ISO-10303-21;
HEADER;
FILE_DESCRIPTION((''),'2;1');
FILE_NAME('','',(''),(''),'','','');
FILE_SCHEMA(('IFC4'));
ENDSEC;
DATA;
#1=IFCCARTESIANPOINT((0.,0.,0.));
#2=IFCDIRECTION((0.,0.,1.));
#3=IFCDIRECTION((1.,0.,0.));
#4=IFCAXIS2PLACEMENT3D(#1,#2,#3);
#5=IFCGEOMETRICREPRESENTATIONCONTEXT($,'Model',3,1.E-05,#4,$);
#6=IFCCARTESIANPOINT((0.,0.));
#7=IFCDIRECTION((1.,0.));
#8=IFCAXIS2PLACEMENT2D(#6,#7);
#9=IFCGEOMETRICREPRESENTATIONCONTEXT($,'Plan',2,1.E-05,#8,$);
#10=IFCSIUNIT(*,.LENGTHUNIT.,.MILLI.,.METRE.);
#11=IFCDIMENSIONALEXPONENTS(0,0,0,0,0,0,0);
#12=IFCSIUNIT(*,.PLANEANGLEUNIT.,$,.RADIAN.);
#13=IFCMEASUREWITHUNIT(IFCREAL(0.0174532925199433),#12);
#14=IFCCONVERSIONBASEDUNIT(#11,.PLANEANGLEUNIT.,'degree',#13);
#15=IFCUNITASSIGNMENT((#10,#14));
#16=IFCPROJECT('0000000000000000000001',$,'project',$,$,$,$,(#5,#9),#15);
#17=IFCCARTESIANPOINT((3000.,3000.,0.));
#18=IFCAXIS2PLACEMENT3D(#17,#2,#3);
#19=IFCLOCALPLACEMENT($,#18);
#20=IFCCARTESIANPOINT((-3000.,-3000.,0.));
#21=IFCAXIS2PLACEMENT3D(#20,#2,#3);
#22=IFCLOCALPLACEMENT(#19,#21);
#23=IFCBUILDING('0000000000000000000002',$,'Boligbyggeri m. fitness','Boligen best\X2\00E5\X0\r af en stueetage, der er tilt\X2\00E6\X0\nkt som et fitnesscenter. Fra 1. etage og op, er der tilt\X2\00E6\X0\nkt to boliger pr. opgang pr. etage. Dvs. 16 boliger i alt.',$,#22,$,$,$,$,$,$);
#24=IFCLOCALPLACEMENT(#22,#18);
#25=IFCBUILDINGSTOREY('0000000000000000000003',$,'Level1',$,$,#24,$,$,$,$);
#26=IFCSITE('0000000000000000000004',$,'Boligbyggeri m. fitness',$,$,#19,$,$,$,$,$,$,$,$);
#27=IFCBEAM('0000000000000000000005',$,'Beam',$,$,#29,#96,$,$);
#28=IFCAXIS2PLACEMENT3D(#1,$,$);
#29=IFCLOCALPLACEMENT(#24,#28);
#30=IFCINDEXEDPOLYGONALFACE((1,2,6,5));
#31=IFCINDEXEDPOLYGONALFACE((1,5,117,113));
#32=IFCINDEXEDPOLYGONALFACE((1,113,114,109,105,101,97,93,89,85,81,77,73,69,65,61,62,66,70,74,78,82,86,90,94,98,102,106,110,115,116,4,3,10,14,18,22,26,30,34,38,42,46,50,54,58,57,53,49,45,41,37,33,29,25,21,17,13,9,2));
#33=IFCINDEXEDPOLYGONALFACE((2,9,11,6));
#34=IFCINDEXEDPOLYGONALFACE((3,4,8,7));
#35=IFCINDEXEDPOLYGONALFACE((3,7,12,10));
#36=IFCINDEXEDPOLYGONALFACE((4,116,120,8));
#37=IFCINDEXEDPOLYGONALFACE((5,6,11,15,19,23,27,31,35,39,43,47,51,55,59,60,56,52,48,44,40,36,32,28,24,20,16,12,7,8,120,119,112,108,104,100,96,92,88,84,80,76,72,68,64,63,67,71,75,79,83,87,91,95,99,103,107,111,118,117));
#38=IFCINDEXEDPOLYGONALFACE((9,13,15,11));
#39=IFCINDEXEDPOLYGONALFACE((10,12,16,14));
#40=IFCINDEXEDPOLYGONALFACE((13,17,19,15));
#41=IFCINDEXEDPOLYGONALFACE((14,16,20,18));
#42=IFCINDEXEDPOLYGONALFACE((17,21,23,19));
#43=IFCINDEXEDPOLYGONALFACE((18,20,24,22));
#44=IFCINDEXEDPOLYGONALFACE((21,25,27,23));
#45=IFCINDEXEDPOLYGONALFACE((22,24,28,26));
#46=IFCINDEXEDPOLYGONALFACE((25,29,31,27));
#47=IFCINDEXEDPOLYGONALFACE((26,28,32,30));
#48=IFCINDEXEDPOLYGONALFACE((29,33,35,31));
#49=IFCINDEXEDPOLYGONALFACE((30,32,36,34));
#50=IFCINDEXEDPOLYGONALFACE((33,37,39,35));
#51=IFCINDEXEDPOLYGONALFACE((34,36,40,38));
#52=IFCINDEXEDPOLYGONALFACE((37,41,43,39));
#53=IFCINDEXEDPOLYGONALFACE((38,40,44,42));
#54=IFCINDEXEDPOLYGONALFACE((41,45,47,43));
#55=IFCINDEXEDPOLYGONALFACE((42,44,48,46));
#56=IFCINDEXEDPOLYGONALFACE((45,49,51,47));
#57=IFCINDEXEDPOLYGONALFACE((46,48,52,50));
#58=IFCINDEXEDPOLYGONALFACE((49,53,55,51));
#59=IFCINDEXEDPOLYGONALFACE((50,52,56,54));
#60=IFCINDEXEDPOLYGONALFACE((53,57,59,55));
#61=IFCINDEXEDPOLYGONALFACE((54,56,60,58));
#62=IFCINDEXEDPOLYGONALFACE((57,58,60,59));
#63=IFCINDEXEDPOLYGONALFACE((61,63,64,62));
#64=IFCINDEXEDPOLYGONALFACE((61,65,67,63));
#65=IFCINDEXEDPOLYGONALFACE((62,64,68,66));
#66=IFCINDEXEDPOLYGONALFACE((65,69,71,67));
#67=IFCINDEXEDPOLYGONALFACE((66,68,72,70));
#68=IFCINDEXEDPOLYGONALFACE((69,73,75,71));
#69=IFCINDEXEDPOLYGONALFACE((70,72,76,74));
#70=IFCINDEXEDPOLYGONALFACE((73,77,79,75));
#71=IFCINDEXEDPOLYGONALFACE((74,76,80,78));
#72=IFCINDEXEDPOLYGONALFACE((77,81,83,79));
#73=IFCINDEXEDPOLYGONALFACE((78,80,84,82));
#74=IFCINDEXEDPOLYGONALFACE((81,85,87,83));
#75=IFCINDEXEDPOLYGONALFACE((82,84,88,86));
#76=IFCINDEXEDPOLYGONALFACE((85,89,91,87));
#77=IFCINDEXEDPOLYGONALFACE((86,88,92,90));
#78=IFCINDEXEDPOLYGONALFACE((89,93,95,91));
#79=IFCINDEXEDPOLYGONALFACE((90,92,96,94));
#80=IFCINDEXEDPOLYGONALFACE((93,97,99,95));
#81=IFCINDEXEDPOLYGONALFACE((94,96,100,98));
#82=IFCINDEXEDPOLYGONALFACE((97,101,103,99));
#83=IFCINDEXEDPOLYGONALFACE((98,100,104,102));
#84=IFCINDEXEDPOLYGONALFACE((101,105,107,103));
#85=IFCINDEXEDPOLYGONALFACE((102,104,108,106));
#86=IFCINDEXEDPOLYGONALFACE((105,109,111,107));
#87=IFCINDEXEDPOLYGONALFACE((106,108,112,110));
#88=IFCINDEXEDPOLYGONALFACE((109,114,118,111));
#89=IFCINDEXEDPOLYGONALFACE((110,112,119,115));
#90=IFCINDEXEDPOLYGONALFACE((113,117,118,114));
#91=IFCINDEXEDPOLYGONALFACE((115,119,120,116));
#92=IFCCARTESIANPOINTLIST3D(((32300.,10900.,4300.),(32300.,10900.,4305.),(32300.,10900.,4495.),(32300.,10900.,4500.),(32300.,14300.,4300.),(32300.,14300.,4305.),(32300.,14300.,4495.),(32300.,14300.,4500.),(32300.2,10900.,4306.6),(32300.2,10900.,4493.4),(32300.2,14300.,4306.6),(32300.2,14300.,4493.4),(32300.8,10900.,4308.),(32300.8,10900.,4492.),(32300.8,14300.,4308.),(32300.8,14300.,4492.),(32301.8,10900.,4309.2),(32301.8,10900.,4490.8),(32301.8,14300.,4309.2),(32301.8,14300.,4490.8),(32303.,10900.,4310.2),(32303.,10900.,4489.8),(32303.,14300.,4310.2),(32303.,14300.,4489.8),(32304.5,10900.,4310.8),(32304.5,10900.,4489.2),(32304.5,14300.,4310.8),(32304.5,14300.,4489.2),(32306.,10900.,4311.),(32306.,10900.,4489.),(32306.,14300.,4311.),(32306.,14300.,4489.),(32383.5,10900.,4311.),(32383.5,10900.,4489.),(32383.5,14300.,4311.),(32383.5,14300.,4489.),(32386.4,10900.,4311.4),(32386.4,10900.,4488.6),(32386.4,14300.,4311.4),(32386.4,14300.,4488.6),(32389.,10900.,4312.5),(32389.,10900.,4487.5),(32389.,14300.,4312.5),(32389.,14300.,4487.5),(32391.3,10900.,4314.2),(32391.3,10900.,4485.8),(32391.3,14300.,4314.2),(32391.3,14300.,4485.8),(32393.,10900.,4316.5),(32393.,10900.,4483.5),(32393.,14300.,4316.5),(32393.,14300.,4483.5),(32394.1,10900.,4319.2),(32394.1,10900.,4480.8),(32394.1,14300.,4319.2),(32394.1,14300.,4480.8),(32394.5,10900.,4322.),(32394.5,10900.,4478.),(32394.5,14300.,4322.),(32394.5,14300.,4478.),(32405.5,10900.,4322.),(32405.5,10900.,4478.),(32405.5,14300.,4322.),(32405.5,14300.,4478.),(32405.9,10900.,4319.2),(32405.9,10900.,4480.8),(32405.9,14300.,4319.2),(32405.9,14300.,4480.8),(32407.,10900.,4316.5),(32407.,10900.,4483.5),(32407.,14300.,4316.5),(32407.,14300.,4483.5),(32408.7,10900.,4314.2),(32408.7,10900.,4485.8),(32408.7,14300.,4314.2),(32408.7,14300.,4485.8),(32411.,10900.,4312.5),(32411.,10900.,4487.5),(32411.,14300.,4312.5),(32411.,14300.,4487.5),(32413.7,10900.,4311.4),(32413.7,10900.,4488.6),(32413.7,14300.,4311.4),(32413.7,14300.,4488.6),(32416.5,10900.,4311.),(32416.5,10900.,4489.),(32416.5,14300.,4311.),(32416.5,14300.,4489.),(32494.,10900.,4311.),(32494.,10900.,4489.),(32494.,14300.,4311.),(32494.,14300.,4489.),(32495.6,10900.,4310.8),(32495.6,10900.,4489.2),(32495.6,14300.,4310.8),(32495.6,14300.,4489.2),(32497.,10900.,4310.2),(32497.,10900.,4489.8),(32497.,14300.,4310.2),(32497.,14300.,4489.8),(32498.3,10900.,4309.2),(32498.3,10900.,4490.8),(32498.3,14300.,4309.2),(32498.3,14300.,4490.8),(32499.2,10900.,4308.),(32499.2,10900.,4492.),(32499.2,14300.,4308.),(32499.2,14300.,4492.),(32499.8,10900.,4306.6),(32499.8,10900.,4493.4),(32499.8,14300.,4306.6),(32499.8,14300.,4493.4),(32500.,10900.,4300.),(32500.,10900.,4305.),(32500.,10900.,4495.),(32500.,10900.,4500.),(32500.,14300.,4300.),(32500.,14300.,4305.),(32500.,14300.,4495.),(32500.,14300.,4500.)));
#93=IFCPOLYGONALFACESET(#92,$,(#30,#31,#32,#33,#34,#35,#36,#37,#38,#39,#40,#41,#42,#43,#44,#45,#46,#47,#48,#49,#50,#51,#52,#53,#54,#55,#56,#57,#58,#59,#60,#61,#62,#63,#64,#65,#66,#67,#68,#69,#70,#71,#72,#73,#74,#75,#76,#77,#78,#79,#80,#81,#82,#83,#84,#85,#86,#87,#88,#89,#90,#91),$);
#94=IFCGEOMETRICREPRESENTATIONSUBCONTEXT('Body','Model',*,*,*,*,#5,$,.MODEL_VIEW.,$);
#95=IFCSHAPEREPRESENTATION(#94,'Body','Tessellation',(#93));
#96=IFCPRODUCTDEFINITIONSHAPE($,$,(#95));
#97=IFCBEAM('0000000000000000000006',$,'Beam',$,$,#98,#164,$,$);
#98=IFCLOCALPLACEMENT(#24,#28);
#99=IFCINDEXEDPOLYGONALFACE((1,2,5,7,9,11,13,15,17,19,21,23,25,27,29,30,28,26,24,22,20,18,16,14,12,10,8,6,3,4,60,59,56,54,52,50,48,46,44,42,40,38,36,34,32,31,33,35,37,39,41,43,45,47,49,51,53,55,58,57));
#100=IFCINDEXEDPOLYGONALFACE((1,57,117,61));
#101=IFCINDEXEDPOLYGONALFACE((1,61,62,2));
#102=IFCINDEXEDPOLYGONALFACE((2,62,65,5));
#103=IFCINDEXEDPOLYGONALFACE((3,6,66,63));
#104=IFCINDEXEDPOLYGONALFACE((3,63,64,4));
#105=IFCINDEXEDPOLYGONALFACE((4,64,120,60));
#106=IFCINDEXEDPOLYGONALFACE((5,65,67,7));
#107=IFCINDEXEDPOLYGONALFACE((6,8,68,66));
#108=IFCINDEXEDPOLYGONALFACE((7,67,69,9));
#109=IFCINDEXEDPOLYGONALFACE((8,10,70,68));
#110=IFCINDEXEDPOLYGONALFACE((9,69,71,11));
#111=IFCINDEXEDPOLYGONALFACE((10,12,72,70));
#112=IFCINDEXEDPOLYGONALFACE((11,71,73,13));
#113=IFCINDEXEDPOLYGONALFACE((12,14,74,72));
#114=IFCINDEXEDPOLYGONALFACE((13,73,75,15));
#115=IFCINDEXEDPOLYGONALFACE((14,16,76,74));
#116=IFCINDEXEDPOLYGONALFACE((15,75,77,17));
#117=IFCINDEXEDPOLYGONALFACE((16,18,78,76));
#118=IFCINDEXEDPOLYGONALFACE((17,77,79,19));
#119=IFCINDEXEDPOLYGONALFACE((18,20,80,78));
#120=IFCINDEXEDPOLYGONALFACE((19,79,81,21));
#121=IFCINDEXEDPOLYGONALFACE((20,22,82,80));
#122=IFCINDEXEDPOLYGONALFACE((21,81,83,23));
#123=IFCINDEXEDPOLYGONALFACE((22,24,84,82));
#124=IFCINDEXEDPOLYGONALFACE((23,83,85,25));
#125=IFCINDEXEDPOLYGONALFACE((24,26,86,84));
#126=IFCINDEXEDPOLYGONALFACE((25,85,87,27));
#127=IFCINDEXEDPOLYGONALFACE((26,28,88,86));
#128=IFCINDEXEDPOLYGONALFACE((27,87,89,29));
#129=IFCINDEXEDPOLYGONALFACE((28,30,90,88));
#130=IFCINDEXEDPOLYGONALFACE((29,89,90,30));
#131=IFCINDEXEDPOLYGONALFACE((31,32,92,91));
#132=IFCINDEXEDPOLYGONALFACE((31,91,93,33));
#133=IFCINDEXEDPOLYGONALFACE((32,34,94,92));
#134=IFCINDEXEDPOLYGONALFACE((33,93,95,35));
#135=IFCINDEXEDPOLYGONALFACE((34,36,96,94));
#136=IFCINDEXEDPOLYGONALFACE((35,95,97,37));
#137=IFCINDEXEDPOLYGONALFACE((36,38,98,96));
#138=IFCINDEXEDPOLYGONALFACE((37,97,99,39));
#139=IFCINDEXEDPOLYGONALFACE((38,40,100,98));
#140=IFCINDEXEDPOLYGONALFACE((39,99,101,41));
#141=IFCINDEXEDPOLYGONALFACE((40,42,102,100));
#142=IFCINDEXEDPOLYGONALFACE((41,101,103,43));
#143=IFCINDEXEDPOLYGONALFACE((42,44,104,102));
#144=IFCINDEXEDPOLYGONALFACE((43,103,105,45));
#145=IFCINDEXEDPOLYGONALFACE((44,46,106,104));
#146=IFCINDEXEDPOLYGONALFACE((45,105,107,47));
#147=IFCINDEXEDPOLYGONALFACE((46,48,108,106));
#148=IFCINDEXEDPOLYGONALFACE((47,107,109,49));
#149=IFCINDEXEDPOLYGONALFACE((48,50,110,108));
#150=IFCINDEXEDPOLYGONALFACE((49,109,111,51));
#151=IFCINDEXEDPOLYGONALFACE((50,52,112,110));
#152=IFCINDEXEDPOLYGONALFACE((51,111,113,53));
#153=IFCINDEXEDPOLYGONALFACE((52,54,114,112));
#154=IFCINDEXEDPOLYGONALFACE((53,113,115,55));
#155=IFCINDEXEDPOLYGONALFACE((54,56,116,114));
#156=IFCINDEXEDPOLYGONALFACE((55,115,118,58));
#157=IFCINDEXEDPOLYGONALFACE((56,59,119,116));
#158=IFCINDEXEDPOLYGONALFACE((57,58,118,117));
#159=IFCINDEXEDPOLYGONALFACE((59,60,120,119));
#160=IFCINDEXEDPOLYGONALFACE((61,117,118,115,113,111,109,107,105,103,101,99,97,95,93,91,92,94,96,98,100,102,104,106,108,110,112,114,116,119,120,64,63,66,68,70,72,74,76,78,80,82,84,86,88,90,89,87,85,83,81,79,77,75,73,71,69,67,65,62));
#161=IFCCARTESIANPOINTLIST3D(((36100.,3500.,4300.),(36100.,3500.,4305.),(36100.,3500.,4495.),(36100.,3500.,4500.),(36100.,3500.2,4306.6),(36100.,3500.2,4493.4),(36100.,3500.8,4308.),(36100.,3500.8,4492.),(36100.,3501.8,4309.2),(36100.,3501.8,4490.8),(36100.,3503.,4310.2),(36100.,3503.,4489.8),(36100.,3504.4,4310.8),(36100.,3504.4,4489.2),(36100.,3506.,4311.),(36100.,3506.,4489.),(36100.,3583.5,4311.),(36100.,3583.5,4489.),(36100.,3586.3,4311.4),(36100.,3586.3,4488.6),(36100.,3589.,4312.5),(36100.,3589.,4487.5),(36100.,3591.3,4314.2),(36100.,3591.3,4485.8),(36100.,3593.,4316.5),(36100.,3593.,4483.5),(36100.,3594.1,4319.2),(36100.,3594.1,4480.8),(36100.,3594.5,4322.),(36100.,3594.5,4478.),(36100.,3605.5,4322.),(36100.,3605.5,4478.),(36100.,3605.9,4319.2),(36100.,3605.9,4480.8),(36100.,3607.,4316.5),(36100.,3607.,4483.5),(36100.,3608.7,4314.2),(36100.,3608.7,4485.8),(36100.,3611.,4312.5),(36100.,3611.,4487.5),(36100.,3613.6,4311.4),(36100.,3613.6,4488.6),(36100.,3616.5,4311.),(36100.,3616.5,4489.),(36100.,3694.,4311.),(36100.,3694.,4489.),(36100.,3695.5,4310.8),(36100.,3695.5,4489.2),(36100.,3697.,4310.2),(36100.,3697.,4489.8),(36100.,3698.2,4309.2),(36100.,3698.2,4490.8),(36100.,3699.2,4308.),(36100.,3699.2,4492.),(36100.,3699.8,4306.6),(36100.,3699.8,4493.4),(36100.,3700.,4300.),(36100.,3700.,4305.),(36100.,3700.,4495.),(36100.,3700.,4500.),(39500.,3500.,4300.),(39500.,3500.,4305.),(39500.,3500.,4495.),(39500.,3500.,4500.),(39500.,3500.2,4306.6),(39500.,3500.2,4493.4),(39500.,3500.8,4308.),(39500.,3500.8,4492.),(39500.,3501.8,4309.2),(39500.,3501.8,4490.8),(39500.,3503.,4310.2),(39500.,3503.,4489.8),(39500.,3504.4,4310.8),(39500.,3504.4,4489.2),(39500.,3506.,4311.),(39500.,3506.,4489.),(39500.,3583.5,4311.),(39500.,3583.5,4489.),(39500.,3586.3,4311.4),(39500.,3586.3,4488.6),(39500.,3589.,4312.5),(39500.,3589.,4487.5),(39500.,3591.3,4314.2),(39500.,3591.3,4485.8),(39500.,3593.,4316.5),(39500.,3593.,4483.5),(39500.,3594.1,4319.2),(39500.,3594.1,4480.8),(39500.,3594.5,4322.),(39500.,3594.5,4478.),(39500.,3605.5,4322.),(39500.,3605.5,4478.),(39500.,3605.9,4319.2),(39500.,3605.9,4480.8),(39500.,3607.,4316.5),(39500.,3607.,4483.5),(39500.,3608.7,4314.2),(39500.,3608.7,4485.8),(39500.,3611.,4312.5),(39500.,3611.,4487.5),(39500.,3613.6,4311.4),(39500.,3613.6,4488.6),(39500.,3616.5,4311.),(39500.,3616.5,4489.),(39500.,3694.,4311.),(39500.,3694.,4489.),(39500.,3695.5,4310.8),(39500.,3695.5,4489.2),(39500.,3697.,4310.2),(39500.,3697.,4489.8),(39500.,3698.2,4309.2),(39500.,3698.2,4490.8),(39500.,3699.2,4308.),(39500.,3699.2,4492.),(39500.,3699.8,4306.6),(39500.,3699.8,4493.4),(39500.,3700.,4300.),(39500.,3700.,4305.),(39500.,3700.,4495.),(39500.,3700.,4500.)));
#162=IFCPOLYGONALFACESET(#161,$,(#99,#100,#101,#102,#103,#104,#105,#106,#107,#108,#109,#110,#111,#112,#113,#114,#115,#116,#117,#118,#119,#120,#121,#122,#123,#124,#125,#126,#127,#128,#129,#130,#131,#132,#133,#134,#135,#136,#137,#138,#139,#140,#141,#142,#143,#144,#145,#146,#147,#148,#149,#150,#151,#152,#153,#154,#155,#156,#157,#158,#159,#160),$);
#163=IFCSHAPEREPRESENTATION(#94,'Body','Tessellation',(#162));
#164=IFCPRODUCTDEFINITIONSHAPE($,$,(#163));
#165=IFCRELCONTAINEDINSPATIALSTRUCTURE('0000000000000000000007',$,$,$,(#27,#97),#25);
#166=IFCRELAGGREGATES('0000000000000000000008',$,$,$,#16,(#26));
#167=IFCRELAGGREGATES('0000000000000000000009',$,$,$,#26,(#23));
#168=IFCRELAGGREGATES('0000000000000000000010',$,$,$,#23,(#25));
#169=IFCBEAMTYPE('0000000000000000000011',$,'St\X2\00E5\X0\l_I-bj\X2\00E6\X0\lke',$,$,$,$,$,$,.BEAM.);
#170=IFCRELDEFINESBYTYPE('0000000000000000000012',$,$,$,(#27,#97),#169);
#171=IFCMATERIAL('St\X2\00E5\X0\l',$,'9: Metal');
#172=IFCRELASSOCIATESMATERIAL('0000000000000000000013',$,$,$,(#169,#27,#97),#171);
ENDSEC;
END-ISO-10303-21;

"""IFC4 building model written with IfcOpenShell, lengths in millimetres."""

from ifc_helpers import new_model, entity, si_unit, converted_unit, frame, origin_with_axes, origin_2d_with_axis, place, context, subcontext, project, spatial, i_section, extrude, material, material_profile, profile_set, profile_usage, type_object, element, save


model = new_model("IFC4")

# Units and contexts
model_context = context("Model", 3, precision=1e-05, world=origin_with_axes())
plan_context = context("Plan", 2, precision=1e-05, world=origin_2d_with_axis())
body_context = subcontext(model_context, "Body", "Model", "MODEL_VIEW")
ifc_project = project(units=[si_unit("LENGTHUNIT", "METRE", prefix="MILLI"), converted_unit("PLANEANGLEUNIT", "degree", entity("IfcReal", 0.0174532925199433), si_unit("PLANEANGLEUNIT", "RADIAN"), dimensions=[0, 0, 0, 0, 0, 0, 0])], contexts=[model_context, plan_context])

# Site, building, storey
site_placement = place(None, frame((3000.0, 3000.0, 0.0), z_axis=(0.0, 0.0, 1.0), x_axis=(1.0, 0.0, 0.0)))
site = spatial("IfcSite", under=ifc_project, at=site_placement, Name="Boligbyggeri m. fitness")
building_placement = place(site_placement, frame((-3000.0, -3000.0, 0.0), z_axis=(0.0, 0.0, 1.0), x_axis=(1.0, 0.0, 0.0)))
building = spatial("IfcBuilding", under=site, at=building_placement, Name="Boligbyggeri m. fitness", Description="Boligen består af en stueetage, der er tiltænkt som et fitnesscenter. Fra 1. etage og op, er der tiltænkt to boliger pr. opgang pr. etage. Dvs. 16 boliger i alt.")
storey_placement = place(building_placement, frame((3000.0, 3000.0, 0.0), z_axis=(0.0, 0.0, 1.0), x_axis=(1.0, 0.0, 0.0)))
storey = spatial("IfcBuildingStorey", under=building, at=storey_placement, Name="Level1")

# Beams
ifc_material_1 = material(Name="Stål", Category="9: Metal")
ifc_material_profile_1 = material_profile(ifc_material_1, i_section(OverallWidth=200.0, OverallDepth=200.0, WebThickness=11.0, FlangeThickness=11.0, FilletRadius=11.0, FlangeEdgeRadius=6.0), Name="Stål", Category="9: Metal")
ifc_profile_set_1 = profile_set([ifc_material_profile_1], Name="NY_I-Profil")
beam_type = type_object("IfcBeamType", Name="Stål_I-bjælke", PredefinedType="BEAM", material=ifc_profile_set_1)
ifc_profile_usage_1 = profile_usage(ifc_profile_set_1, cardinal=9)
beam_1_placement = place(storey_placement, frame((32500.0, 10900.0, 4500.0), z_axis=(0.0, 1.0, 0.0), x_axis=(-1.0, 0.0, 0.0)))
element("IfcBeam", 1, at=beam_1_placement, inside=storey, type_object=beam_type, material=ifc_profile_usage_1, Name="Beam", context=body_context, shape_type="SweptSolid", body=[
    extrude(i_section(OverallWidth=200.0, OverallDepth=200.0, WebThickness=11.0, FlangeThickness=11.0, FilletRadius=11.0, FlangeEdgeRadius=6.0), frame((100.0, -100.0, 0.0), z_axis=(0.0, 0.0, 1.0), x_axis=(1.0, 0.0, 0.0)), (0.0, 0.0, 1.0), 3400.0),
])
ifc_profile_usage_2 = profile_usage(ifc_profile_set_1, cardinal=7)
beam_2_placement = place(storey_placement, frame((36100.0, 3700.0, 4500.0), z_axis=(1.0, 0.0, 0.0), x_axis=(0.0, 1.0, 0.0)))
element("IfcBeam", 2, at=beam_2_placement, inside=storey, type_object=beam_type, material=ifc_profile_usage_2, Name="Beam", context=body_context, shape_type="SweptSolid", body=[
    extrude(i_section(OverallWidth=200.0, OverallDepth=200.0, WebThickness=11.0, FlangeThickness=11.0, FilletRadius=11.0, FlangeEdgeRadius=6.0), frame((-100.0, -100.0, 0.0), z_axis=(0.0, 0.0, 1.0), x_axis=(1.0, 0.0, 0.0)), (0.0, 0.0, 1.0), 3400.0),
])

save(model, "model.ifc")
